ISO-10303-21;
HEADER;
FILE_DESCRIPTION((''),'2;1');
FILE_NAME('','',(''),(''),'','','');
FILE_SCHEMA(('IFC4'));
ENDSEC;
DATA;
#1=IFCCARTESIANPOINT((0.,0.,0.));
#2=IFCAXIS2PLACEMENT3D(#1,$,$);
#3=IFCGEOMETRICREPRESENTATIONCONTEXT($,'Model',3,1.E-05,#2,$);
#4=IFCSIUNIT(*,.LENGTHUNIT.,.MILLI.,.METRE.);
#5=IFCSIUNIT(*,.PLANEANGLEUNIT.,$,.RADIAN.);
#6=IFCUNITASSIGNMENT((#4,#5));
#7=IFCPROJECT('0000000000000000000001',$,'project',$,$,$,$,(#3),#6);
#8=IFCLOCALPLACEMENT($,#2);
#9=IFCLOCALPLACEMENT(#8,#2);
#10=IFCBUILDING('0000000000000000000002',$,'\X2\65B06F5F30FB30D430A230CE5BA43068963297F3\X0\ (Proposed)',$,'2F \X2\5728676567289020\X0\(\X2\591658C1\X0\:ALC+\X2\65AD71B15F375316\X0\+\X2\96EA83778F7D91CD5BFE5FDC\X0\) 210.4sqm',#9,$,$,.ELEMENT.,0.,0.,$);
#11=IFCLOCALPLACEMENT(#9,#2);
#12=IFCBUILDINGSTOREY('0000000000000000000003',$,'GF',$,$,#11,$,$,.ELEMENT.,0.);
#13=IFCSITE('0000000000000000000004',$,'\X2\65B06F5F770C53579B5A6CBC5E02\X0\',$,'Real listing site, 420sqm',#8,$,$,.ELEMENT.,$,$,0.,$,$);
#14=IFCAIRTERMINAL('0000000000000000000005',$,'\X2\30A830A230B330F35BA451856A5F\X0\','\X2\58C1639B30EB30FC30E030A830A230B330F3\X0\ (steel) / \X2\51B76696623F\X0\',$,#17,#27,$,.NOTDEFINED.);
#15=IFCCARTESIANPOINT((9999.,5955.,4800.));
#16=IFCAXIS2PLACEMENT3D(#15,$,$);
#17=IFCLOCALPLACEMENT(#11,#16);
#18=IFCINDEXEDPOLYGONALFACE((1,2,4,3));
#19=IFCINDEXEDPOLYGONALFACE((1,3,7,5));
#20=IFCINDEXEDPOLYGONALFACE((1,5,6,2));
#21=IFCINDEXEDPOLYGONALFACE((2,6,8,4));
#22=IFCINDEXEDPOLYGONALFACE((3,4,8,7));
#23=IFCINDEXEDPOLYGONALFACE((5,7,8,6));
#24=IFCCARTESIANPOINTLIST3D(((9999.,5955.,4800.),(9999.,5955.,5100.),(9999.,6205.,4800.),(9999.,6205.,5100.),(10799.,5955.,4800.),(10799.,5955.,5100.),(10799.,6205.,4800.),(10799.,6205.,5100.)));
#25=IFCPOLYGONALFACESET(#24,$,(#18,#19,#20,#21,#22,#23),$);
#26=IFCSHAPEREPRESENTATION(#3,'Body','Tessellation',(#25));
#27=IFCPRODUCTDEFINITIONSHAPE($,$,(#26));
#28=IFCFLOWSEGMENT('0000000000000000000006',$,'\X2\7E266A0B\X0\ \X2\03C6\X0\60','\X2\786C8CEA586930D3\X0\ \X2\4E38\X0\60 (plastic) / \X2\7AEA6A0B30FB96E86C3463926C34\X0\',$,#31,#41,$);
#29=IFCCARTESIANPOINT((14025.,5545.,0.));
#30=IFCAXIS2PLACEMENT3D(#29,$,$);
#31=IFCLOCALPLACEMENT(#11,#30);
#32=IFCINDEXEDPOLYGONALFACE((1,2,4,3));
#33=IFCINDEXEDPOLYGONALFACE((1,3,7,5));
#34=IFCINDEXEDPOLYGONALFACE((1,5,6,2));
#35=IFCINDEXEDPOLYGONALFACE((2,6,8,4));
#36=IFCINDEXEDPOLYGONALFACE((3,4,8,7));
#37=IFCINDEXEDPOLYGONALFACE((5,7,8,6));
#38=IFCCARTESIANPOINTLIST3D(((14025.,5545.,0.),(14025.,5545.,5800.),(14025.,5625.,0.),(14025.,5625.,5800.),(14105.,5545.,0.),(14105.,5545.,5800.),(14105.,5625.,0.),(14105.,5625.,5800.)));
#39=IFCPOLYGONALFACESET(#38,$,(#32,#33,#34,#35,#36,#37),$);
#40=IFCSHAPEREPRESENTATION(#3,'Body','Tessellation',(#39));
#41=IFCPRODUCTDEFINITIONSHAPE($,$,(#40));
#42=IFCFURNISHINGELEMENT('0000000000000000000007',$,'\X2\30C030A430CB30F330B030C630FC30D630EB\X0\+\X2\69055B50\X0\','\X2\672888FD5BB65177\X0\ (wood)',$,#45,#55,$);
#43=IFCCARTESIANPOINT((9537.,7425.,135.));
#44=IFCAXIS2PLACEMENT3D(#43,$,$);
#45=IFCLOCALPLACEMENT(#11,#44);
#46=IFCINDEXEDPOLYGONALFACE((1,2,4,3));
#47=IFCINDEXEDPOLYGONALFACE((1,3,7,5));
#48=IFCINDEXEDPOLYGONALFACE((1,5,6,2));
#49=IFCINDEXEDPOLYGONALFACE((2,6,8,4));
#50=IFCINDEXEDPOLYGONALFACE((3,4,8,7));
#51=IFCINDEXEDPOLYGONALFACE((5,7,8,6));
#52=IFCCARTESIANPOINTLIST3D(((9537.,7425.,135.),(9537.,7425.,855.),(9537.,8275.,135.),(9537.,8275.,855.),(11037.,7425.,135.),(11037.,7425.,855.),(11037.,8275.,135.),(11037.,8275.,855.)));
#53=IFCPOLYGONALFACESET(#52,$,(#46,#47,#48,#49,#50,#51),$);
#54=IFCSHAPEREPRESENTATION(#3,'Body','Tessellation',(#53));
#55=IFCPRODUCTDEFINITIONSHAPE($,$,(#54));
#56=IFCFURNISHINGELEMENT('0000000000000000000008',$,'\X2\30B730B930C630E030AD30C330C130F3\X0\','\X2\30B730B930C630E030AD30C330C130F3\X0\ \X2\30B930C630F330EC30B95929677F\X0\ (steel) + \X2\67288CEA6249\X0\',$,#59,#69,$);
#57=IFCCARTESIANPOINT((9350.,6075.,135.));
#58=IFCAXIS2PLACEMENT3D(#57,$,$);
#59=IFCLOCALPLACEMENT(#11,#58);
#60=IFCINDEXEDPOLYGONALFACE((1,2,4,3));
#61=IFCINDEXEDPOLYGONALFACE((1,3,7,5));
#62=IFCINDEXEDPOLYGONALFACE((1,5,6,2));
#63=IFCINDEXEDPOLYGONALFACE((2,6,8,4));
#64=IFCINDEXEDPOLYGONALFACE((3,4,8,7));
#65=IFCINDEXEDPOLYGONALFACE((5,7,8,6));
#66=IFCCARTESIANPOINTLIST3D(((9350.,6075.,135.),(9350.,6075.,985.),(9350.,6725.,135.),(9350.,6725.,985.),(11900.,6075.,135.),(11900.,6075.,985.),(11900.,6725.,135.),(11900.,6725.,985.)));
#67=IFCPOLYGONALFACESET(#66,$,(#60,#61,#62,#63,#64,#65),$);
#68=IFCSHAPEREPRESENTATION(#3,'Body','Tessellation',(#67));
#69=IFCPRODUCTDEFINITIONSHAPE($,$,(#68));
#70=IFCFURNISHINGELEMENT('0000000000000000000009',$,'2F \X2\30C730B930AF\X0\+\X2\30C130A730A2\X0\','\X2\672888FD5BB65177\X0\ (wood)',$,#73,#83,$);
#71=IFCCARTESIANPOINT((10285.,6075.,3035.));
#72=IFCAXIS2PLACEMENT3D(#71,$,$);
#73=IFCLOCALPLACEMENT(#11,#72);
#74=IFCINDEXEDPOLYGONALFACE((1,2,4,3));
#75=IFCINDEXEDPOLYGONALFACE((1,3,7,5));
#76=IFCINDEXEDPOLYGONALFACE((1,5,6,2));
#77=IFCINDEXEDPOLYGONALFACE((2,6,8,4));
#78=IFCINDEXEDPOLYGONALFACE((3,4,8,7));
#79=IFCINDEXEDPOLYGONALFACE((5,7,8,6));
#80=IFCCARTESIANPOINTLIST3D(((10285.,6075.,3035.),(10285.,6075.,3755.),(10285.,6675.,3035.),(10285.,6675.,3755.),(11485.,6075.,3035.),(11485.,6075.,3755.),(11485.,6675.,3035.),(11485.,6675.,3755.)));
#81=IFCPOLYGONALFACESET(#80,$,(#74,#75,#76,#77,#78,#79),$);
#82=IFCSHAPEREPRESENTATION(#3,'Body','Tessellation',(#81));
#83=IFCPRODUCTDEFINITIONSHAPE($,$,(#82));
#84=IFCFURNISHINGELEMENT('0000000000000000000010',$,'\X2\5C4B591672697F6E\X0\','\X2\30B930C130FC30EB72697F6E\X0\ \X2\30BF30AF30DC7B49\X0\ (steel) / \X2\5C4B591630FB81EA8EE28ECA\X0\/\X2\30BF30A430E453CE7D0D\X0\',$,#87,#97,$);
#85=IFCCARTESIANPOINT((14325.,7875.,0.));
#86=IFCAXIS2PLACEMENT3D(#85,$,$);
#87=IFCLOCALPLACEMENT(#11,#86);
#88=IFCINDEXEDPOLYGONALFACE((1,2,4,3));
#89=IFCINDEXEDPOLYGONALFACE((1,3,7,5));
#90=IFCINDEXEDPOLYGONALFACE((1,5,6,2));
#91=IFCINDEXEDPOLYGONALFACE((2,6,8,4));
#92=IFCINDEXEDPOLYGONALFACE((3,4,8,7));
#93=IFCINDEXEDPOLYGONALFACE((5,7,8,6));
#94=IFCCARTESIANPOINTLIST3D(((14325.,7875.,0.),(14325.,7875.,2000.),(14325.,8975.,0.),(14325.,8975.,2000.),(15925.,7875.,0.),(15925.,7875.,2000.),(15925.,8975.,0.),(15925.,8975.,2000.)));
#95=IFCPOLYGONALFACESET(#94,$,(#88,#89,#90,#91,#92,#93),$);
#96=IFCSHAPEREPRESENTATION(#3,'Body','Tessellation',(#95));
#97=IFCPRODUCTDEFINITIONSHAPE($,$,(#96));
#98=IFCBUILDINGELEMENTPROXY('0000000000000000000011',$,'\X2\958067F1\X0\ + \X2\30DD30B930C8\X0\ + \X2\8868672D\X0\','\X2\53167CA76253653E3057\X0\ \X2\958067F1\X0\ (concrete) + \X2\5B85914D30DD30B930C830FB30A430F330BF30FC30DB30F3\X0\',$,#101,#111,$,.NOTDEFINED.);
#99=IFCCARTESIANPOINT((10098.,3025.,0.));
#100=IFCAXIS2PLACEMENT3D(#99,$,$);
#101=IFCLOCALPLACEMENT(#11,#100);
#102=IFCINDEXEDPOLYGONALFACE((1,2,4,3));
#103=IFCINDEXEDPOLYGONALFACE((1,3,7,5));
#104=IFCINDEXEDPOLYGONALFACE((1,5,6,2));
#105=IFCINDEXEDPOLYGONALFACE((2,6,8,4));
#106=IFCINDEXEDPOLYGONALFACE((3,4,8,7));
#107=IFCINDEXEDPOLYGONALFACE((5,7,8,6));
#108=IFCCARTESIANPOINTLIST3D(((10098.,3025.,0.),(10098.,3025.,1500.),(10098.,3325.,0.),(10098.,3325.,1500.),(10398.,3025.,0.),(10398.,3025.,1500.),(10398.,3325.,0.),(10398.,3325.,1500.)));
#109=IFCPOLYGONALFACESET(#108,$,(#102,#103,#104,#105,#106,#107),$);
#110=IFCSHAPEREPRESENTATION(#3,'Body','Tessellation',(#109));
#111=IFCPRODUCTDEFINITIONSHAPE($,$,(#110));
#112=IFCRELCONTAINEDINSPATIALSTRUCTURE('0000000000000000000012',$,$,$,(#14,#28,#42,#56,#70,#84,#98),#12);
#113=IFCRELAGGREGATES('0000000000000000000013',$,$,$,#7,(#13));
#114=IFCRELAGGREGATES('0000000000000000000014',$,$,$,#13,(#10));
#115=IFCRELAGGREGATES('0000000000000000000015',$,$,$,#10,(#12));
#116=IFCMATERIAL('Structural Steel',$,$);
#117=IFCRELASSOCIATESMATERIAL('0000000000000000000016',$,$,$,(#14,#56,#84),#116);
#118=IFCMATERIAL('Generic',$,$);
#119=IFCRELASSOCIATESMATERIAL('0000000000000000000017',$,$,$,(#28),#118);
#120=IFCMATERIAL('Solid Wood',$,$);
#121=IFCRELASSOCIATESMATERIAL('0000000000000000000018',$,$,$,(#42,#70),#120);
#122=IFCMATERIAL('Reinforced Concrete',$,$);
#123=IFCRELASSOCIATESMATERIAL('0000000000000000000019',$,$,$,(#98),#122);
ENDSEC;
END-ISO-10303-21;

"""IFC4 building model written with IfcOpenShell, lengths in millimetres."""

from ifc_helpers import new_model, si_unit, frame, frame_2d, origin, place, context, project, spatial, rectangle, extrude, material, element, save


model = new_model("IFC4")

# Units and contexts
model_context = context("Model", 3, precision=1e-05, world=origin())
ifc_project = project(units=[si_unit("LENGTHUNIT", "METRE", prefix="MILLI"), si_unit("PLANEANGLEUNIT", "RADIAN")], contexts=[model_context])

# Site, building, storey
site_placement = place(None, origin())
site = spatial("IfcSite", under=ifc_project, at=site_placement, Name="新潟県南魚沼市", ObjectType="Real listing site, 420sqm", CompositionType="ELEMENT", RefElevation=0.0)
building_placement = place(site_placement, origin())
building = spatial("IfcBuilding", under=site, at=building_placement, Name="新潟・ピアノ室と防音 (Proposed)", ObjectType="2F 在来木造(外壁:ALC+断熱強化+雪荷载重対応) 210.4sqm", CompositionType="ELEMENT", ElevationOfRefHeight=0.0, ElevationOfTerrain=0.0)
storey_placement = place(building_placement, origin())
storey = spatial("IfcBuildingStorey", under=building, at=storey_placement, Name="GF", CompositionType="ELEMENT", Elevation=0.0)

# Shared definitions
ifc_material_1 = material(Name="Solid Wood")

# Shared definitions
ifc_material_2 = material(Name="Reinforced Concrete")

# Shared definitions
ifc_material_3 = material(Name="Structural Steel")

# Shared definitions
ifc_material_4 = material(Name="Generic")

# Air terminal
air_terminal_placement = place(storey_placement, frame((9999.0, 5955.0, 4800.0)))
element("IfcAirTerminal", 1, at=air_terminal_placement, inside=storey, material=ifc_material_3, Name="エアコン室内機", Description="壁掛ルームエアコン (steel) / 冷暖房", PredefinedType="NOTDEFINED", context=model_context, shape_type="SweptSolid", body=[
    extrude(rectangle(XDim=800.0, YDim=250.0, at=frame_2d((400.0, 125.0))), frame((9999.0, 5955.0, 4800.0)), (0.0, 0.0, 1.0), 300.0),
])

# Flow segment
flow_segment_placement = place(storey_placement, frame((14025.0, 5545.0, 0.0)))
element("IfcFlowSegment", 2, at=flow_segment_placement, inside=storey, material=ifc_material_4, Name="縦樋 φ60", Description="硬質塩ビ 丸60 (plastic) / 竪樋・雨水排水", context=model_context, shape_type="SweptSolid", body=[
    extrude(rectangle(XDim=80.0, YDim=80.0, at=frame_2d((40.0, 40.0))), frame((14025.0, 5545.0, 0.0)), (0.0, 0.0, 1.0), 5800.0),
])

# Furnishing elements
furnishing_1_placement = place(storey_placement, frame((9537.0, 7425.0, 135.0)))
element("IfcFurnishingElement", 3, at=furnishing_1_placement, inside=storey, material=ifc_material_1, Name="ダイニングテーブル+椅子", Description="木製家具 (wood)", context=model_context, shape_type="SweptSolid", body=[
    extrude(rectangle(XDim=1500.0, YDim=850.0, at=frame_2d((750.0, 425.0))), frame((9537.0, 7425.0, 135.0)), (0.0, 0.0, 1.0), 720.0),
])
furnishing_2_placement = place(storey_placement, frame((9350.0, 6075.0, 135.0)))
element("IfcFurnishingElement", 4, at=furnishing_2_placement, inside=storey, material=ifc_material_3, Name="システムキッチン", Description="システムキッチン ステンレス天板 (steel) + 木質扉", context=model_context, shape_type="SweptSolid", body=[
    extrude(rectangle(XDim=2550.0, YDim=650.0, at=frame_2d((1275.0, 325.0))), frame((9350.0, 6075.0, 135.0)), (0.0, 0.0, 1.0), 850.0),
])
furnishing_3_placement = place(storey_placement, frame((10285.0, 6075.0, 3035.0)))
element("IfcFurnishingElement", 5, at=furnishing_3_placement, inside=storey, material=ifc_material_1, Name="2F デスク+チェア", Description="木製家具 (wood)", context=model_context, shape_type="SweptSolid", body=[
    extrude(rectangle(XDim=1200.0, YDim=600.0, at=frame_2d((600.0, 300.0))), frame((10285.0, 6075.0, 3035.0)), (0.0, 0.0, 1.0), 720.0),
])
furnishing_4_placement = place(storey_placement, frame((14325.0, 7875.0, 0.0)))
element("IfcFurnishingElement", 6, at=furnishing_4_placement, inside=storey, material=ifc_material_3, Name="屋外物置", Description="スチール物置 タクボ等 (steel) / 屋外・自転車/タイヤ収納", context=model_context, shape_type="SweptSolid", body=[
    extrude(rectangle(XDim=1600.0, YDim=1100.0, at=frame_2d((800.0, 550.0))), frame((14325.0, 7875.0, 0.0)), (0.0, 0.0, 1.0), 2000.0),
])

# Building element proxy
proxy_placement = place(storey_placement, frame((10098.0, 3025.0, 0.0)))
element("IfcBuildingElementProxy", 7, at=proxy_placement, inside=storey, material=ifc_material_2, Name="門柱 + ポスト + 表札", Description="化粧打放し 門柱 (concrete) + 宅配ポスト・インターホン", PredefinedType="NOTDEFINED", context=model_context, shape_type="SweptSolid", body=[
    extrude(rectangle(XDim=300.0, YDim=300.0, at=frame_2d((150.0, 150.0))), frame((10098.0, 3025.0, 0.0)), (0.0, 0.0, 1.0), 1500.0),
])

save(model, "model.ifc")
